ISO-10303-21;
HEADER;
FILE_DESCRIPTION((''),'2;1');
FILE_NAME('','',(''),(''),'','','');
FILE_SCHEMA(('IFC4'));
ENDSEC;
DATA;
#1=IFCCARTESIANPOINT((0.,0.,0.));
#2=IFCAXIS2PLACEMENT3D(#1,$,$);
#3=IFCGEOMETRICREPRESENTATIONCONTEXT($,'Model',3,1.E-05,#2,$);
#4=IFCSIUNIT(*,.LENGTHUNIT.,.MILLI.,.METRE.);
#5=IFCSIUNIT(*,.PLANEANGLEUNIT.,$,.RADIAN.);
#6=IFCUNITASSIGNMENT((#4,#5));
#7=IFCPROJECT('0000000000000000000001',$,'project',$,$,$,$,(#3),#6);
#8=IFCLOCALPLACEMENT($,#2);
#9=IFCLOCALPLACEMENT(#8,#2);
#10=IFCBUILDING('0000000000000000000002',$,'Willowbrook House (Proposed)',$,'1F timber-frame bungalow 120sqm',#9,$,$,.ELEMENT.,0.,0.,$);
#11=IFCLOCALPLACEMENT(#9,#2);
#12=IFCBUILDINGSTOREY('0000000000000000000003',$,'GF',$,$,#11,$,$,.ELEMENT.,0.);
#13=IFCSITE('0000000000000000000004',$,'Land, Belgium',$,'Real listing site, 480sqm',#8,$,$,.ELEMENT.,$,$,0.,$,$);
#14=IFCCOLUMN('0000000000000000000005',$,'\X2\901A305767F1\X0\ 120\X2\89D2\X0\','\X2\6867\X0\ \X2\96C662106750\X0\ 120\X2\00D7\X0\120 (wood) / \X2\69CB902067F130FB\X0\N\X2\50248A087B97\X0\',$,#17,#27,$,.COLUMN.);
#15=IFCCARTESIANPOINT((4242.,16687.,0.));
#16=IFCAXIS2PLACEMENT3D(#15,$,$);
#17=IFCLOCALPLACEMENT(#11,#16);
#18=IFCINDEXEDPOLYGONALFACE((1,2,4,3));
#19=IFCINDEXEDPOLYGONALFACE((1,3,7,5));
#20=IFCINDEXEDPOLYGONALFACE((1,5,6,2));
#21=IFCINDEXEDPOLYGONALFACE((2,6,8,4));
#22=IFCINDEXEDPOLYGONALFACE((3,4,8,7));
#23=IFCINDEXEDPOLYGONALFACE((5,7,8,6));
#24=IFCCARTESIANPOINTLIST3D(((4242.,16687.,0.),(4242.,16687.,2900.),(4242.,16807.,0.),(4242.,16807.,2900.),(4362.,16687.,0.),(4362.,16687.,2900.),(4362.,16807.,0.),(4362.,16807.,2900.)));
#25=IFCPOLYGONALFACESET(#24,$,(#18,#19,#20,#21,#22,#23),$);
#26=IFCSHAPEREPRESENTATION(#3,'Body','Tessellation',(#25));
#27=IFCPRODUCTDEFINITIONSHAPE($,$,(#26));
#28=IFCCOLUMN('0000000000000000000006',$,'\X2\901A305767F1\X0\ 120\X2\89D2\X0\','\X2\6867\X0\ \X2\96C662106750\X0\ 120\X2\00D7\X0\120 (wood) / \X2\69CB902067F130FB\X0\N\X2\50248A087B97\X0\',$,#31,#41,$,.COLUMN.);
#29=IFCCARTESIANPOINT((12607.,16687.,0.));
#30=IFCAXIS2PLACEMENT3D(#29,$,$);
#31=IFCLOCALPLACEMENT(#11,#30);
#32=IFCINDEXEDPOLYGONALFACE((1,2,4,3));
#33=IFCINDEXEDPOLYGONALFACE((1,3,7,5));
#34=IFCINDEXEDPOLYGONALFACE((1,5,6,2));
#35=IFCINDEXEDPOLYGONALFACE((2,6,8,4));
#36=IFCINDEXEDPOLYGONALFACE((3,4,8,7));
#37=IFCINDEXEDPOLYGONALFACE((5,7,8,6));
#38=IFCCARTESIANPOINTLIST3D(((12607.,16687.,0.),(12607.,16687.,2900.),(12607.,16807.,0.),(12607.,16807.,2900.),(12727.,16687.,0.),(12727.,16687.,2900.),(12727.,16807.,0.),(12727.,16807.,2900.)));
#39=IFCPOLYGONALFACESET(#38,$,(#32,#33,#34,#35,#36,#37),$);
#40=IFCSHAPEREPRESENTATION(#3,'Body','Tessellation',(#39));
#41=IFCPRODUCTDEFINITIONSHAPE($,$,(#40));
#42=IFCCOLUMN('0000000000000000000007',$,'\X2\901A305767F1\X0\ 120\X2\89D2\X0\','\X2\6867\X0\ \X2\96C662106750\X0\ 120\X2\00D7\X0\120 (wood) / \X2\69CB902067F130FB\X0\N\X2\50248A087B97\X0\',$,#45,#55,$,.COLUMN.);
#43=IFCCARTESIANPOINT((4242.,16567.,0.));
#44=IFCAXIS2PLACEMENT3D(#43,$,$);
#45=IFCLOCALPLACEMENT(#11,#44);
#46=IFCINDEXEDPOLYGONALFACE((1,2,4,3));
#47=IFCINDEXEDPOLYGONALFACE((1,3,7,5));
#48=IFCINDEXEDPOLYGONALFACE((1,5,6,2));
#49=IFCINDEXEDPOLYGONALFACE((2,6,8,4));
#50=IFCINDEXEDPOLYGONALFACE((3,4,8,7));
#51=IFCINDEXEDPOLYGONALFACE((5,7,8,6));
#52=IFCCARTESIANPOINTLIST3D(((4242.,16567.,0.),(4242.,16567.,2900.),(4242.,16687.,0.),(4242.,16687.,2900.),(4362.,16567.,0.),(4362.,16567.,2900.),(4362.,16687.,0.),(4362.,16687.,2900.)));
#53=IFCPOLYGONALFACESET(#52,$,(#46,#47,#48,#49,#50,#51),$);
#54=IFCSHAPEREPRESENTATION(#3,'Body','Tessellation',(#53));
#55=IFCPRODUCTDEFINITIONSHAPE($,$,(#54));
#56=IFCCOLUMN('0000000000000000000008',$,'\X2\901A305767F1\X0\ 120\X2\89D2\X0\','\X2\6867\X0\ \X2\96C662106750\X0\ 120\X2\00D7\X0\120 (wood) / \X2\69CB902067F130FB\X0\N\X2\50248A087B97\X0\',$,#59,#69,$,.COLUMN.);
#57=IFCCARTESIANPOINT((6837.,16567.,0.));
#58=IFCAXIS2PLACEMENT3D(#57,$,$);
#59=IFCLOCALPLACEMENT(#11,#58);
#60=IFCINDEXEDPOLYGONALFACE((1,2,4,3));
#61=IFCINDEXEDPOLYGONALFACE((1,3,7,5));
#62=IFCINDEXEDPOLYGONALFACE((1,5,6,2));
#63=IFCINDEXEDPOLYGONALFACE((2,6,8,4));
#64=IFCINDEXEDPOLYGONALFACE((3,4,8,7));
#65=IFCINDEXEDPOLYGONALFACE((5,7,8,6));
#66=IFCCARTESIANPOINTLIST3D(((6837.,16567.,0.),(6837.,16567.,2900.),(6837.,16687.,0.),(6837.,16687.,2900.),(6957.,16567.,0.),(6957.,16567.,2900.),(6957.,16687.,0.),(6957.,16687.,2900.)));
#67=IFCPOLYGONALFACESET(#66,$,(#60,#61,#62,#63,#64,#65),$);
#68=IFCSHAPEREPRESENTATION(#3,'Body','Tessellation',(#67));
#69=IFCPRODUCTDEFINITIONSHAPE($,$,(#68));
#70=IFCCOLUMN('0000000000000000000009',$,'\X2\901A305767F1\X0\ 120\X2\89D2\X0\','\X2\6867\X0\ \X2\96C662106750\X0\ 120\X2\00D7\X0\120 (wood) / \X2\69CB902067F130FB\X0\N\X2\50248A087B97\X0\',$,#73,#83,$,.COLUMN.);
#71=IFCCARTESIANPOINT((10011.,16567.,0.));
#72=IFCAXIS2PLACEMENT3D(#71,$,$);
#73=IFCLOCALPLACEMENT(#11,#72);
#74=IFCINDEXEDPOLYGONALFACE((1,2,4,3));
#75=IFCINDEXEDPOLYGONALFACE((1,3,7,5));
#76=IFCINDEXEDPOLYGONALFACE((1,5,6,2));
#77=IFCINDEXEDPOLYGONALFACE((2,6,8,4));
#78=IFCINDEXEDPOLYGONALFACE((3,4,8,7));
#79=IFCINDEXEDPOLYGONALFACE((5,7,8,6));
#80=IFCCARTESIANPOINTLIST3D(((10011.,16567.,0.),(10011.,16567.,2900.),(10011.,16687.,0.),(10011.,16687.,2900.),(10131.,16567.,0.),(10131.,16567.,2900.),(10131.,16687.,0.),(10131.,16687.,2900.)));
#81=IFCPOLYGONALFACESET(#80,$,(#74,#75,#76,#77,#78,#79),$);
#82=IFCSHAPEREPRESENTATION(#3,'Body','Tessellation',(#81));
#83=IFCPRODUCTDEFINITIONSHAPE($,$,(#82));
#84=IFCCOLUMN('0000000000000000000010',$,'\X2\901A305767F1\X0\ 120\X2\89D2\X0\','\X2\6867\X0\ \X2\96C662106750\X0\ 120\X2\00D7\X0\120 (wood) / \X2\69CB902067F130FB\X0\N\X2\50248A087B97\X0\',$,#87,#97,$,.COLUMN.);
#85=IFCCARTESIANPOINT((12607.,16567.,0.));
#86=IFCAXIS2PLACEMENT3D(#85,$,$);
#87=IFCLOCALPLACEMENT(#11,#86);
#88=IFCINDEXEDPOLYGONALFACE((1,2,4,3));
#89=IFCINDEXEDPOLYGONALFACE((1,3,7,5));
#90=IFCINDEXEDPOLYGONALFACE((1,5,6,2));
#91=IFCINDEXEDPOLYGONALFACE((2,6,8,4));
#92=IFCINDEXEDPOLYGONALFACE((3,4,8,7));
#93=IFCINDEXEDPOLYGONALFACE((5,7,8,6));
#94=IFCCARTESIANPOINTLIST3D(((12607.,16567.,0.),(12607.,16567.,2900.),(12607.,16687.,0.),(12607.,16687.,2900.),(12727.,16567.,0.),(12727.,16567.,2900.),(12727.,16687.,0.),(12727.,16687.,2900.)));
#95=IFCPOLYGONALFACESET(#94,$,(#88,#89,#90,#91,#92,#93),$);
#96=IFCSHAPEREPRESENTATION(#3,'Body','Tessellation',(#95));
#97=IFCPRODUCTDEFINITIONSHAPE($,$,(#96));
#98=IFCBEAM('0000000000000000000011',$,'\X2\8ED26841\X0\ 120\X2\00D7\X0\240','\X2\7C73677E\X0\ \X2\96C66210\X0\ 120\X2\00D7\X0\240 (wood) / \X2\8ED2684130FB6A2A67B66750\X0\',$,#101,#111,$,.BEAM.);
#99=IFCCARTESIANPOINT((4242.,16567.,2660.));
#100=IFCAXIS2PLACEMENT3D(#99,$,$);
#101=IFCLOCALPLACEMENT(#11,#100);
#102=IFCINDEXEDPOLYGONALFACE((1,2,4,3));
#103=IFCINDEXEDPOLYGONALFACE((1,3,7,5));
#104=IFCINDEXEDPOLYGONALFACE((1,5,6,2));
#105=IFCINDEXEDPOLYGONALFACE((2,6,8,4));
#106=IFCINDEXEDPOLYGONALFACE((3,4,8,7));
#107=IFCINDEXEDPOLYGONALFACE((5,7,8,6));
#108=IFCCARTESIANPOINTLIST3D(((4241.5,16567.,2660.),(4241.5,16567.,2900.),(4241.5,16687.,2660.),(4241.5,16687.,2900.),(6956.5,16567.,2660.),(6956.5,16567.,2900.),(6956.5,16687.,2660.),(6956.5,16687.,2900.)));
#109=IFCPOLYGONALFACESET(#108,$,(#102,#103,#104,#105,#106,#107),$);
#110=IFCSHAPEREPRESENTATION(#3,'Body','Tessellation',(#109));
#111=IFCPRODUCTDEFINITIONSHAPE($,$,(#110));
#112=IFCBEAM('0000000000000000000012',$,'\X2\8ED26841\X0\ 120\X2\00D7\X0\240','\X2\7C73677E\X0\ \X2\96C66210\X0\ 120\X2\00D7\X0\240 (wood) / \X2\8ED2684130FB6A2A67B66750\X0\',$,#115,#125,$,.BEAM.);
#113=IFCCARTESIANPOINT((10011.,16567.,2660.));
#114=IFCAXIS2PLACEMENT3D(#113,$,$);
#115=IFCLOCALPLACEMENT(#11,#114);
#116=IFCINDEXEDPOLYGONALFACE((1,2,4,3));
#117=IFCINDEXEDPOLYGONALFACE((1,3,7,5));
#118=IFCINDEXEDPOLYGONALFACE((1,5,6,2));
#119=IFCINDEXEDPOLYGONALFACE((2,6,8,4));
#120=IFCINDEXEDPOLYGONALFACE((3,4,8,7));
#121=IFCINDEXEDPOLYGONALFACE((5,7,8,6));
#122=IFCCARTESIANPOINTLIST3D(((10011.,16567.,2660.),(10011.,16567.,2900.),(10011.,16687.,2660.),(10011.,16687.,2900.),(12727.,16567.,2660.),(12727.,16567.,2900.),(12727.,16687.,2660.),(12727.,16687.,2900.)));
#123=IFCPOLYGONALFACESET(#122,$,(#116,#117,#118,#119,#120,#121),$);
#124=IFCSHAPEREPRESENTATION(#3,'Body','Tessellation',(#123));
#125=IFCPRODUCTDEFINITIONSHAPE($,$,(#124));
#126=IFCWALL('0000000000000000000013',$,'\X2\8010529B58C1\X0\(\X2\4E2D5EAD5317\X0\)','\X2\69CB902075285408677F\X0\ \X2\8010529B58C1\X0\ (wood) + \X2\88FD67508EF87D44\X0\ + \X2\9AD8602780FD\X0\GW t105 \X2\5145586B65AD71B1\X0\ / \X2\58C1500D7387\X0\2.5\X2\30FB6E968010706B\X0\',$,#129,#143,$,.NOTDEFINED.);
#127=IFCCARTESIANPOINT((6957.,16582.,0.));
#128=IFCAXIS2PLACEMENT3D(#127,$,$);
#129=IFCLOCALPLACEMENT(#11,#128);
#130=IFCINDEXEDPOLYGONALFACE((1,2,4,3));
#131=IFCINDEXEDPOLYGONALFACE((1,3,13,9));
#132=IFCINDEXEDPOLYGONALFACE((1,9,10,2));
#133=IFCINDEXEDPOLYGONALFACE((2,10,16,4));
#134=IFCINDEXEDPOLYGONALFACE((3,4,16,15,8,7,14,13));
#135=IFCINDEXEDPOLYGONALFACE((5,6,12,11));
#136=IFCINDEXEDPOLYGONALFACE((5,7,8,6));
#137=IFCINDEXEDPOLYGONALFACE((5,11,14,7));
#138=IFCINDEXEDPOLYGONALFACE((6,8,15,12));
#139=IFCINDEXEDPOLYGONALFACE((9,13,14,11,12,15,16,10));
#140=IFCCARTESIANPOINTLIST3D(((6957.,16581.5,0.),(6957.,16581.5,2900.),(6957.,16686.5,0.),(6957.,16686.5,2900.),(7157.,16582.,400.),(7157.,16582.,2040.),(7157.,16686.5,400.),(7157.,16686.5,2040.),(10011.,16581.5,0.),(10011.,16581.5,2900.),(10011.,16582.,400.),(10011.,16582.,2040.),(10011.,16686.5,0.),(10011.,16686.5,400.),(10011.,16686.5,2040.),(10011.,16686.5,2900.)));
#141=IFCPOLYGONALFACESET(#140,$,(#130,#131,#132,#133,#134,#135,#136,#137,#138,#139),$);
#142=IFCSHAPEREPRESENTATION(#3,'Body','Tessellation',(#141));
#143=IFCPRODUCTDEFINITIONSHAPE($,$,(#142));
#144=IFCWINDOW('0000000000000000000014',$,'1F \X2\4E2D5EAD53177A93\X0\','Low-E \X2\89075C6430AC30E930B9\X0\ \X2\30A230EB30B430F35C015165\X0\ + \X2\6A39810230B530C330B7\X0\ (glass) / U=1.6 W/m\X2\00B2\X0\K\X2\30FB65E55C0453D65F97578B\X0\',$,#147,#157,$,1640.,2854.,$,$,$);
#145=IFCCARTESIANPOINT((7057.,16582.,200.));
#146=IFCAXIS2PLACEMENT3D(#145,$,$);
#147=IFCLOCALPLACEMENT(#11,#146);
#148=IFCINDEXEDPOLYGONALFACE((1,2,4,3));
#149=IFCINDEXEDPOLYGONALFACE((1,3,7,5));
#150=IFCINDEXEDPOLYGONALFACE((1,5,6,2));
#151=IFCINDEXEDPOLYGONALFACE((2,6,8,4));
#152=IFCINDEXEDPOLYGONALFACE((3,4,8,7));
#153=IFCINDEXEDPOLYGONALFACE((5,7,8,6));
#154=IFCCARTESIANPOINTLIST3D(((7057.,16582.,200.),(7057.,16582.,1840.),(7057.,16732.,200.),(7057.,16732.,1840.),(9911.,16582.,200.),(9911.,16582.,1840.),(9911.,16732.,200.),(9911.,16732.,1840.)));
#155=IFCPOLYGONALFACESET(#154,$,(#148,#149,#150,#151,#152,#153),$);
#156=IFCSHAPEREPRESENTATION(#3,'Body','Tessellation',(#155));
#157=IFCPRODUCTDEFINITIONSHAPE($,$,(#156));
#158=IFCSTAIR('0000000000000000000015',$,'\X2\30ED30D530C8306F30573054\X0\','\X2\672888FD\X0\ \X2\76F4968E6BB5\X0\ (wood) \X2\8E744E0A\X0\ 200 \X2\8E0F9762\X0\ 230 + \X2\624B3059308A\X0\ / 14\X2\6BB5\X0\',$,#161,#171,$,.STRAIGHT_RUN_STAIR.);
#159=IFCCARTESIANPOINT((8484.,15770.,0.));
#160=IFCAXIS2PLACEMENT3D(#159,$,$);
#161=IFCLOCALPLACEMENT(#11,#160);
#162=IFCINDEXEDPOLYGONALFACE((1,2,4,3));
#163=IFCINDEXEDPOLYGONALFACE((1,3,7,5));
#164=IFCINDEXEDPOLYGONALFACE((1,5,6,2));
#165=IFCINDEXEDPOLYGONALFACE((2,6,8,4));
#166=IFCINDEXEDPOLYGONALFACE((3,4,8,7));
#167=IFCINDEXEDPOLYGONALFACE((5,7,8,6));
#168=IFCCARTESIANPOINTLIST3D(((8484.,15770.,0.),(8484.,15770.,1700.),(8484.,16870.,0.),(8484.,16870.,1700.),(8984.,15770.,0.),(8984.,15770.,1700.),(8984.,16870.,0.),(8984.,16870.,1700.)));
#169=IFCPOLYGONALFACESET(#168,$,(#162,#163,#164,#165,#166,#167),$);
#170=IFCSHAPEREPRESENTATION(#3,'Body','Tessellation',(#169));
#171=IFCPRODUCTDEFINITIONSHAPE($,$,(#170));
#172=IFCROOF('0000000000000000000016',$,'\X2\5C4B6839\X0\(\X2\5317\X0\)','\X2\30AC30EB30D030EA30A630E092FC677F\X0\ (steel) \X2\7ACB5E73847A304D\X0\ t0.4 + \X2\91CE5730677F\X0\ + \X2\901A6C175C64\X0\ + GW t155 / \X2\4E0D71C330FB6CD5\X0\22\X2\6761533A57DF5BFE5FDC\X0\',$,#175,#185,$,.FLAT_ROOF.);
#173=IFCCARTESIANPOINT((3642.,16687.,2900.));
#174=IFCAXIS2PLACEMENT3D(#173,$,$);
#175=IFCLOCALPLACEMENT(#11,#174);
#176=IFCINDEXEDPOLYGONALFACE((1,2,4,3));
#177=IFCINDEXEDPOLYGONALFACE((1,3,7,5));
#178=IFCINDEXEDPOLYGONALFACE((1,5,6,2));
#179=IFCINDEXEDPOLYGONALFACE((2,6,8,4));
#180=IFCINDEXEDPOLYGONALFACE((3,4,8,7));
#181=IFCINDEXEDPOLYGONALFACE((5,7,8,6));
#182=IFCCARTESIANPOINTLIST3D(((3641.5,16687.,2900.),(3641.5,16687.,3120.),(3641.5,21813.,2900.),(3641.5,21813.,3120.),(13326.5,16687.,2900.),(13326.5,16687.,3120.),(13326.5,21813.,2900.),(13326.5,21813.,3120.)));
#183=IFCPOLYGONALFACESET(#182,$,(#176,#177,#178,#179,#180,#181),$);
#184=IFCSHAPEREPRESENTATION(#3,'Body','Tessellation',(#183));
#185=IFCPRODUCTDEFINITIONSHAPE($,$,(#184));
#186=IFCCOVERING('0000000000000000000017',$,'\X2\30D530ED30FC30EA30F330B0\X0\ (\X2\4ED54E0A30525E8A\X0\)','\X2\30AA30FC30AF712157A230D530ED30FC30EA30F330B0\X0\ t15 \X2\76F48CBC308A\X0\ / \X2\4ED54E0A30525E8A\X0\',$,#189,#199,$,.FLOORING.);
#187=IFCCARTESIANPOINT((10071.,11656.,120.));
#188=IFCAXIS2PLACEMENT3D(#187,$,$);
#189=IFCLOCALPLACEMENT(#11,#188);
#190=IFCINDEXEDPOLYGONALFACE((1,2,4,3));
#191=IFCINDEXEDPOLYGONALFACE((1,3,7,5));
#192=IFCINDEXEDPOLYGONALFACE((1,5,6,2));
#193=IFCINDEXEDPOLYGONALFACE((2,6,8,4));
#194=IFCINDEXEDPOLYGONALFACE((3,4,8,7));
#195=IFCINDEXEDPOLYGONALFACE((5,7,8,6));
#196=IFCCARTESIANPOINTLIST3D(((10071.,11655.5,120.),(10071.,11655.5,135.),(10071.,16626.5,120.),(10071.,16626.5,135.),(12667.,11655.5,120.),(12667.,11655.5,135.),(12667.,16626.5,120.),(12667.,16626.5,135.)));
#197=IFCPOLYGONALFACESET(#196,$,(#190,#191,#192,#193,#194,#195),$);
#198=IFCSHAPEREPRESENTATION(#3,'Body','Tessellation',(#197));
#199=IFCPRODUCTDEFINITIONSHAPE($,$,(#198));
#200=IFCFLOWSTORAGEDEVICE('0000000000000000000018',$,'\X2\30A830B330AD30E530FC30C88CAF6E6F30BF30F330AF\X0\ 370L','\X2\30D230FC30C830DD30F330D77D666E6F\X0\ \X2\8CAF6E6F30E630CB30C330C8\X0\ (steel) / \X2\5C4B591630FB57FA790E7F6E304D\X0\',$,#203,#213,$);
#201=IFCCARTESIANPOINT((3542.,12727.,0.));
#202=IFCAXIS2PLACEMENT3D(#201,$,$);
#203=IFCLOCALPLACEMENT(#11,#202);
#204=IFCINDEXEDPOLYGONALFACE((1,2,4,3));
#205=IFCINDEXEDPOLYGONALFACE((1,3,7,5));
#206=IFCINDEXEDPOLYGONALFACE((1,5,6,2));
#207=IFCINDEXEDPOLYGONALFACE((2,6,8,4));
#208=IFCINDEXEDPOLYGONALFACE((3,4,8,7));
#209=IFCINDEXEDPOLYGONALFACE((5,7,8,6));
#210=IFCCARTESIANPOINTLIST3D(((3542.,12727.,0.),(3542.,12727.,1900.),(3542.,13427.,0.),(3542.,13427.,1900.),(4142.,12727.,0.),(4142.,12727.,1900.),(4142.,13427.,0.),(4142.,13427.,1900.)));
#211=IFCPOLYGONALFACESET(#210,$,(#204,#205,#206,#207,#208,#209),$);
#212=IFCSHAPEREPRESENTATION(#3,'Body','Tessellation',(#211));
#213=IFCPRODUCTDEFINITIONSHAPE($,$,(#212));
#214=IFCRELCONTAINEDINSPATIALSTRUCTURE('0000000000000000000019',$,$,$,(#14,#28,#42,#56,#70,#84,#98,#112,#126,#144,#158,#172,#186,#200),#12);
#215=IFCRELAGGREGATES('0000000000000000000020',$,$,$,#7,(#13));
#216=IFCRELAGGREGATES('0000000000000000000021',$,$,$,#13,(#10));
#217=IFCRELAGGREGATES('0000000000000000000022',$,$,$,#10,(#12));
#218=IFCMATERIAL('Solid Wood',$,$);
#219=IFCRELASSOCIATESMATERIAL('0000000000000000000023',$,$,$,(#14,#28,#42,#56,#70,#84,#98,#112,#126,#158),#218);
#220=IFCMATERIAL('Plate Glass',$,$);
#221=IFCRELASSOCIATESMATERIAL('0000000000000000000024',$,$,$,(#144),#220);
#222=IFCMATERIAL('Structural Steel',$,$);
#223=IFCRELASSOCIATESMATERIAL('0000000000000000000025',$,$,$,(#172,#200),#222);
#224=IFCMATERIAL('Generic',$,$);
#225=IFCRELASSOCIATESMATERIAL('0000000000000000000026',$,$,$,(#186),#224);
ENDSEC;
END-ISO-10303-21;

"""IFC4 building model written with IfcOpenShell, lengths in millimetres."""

from ifc_helpers import new_model, si_unit, frame, frame_2d, origin, place, context, project, spatial, rectangle, extrude, material, element, fill, save


model = new_model("IFC4")

# Units and contexts
model_context = context("Model", 3, precision=1e-05, world=origin())
ifc_project = project(units=[si_unit("LENGTHUNIT", "METRE", prefix="MILLI"), si_unit("PLANEANGLEUNIT", "RADIAN")], contexts=[model_context])

# Site, building, storey
site_placement = place(None, origin())
site = spatial("IfcSite", under=ifc_project, at=site_placement, Name="Land, Belgium", ObjectType="Real listing site, 480sqm", CompositionType="ELEMENT", RefElevation=0.0)
building_placement = place(site_placement, origin())
building = spatial("IfcBuilding", under=site, at=building_placement, Name="Willowbrook House (Proposed)", ObjectType="1F timber-frame bungalow 120sqm", CompositionType="ELEMENT", ElevationOfRefHeight=0.0, ElevationOfTerrain=0.0)
storey_placement = place(building_placement, origin())
storey = spatial("IfcBuildingStorey", under=building, at=storey_placement, Name="GF", CompositionType="ELEMENT", Elevation=0.0)

# Columns
ifc_material_1 = material(Name="Solid Wood")
column_1_placement = place(storey_placement, frame((4242.0, 16687.0, 0.0)))
element("IfcColumn", 1, at=column_1_placement, inside=storey, material=ifc_material_1, Name="通し柱 120角", Description="桧 集成材 120×120 (wood) / 構造柱・N値計算", PredefinedType="COLUMN", context=model_context, shape_type="SweptSolid", body=[
    extrude(rectangle(XDim=120.0, YDim=120.0, at=frame_2d((60.0, 60.0))), frame((4242.0, 16687.0, 0.0)), (0.0, 0.0, 1.0), 2900.0),
])
column_2_placement = place(storey_placement, frame((12607.0, 16687.0, 0.0)))
element("IfcColumn", 2, at=column_2_placement, inside=storey, material=ifc_material_1, Name="通し柱 120角", Description="桧 集成材 120×120 (wood) / 構造柱・N値計算", PredefinedType="COLUMN", context=model_context, shape_type="SweptSolid", body=[
    extrude(rectangle(XDim=120.0, YDim=120.0, at=frame_2d((60.0, 60.0))), frame((12607.0, 16687.0, 0.0)), (0.0, 0.0, 1.0), 2900.0),
])
column_3_placement = place(storey_placement, frame((4242.0, 16567.0, 0.0)))
element("IfcColumn", 3, at=column_3_placement, inside=storey, material=ifc_material_1, Name="通し柱 120角", Description="桧 集成材 120×120 (wood) / 構造柱・N値計算", PredefinedType="COLUMN", context=model_context, shape_type="SweptSolid", body=[
    extrude(rectangle(XDim=120.0, YDim=120.0, at=frame_2d((60.0, 60.0))), frame((4242.0, 16567.0, 0.0)), (0.0, 0.0, 1.0), 2900.0),
])
column_4_placement = place(storey_placement, frame((6837.0, 16567.0, 0.0)))
element("IfcColumn", 4, at=column_4_placement, inside=storey, material=ifc_material_1, Name="通し柱 120角", Description="桧 集成材 120×120 (wood) / 構造柱・N値計算", PredefinedType="COLUMN", context=model_context, shape_type="SweptSolid", body=[
    extrude(rectangle(XDim=120.0, YDim=120.0, at=frame_2d((60.0, 60.0))), frame((6837.0, 16567.0, 0.0)), (0.0, 0.0, 1.0), 2900.0),
])
column_5_placement = place(storey_placement, frame((10011.0, 16567.0, 0.0)))
element("IfcColumn", 5, at=column_5_placement, inside=storey, material=ifc_material_1, Name="通し柱 120角", Description="桧 集成材 120×120 (wood) / 構造柱・N値計算", PredefinedType="COLUMN", context=model_context, shape_type="SweptSolid", body=[
    extrude(rectangle(XDim=120.0, YDim=120.0, at=frame_2d((60.0, 60.0))), frame((10011.0, 16567.0, 0.0)), (0.0, 0.0, 1.0), 2900.0),
])
column_6_placement = place(storey_placement, frame((12607.0, 16567.0, 0.0)))
element("IfcColumn", 6, at=column_6_placement, inside=storey, material=ifc_material_1, Name="通し柱 120角", Description="桧 集成材 120×120 (wood) / 構造柱・N値計算", PredefinedType="COLUMN", context=model_context, shape_type="SweptSolid", body=[
    extrude(rectangle(XDim=120.0, YDim=120.0, at=frame_2d((60.0, 60.0))), frame((12607.0, 16567.0, 0.0)), (0.0, 0.0, 1.0), 2900.0),
])

# Beams
beam_1_placement = place(storey_placement, frame((4242.0, 16567.0, 2660.0)))
element("IfcBeam", 7, at=beam_1_placement, inside=storey, material=ifc_material_1, Name="軒桁 120×240", Description="米松 集成 120×240 (wood) / 軒桁・横架材", PredefinedType="BEAM", context=model_context, shape_type="SweptSolid", body=[
    extrude(rectangle(XDim=2715.0, YDim=120.0, at=frame_2d((1357.0, 60.0))), frame((4242.0, 16567.0, 2660.0)), (0.0, 0.0, 1.0), 240.0),
])
beam_2_placement = place(storey_placement, frame((10011.0, 16567.0, 2660.0)))
element("IfcBeam", 8, at=beam_2_placement, inside=storey, material=ifc_material_1, Name="軒桁 120×240", Description="米松 集成 120×240 (wood) / 軒桁・横架材", PredefinedType="BEAM", context=model_context, shape_type="SweptSolid", body=[
    extrude(rectangle(XDim=2716.0, YDim=120.0, at=frame_2d((1358.0, 60.0))), frame((10011.0, 16567.0, 2660.0)), (0.0, 0.0, 1.0), 240.0),
])

# Wall, opening, window
wall_placement = place(storey_placement, frame((6957.0, 16582.0, 0.0)))
wall = element("IfcWall", 9, at=wall_placement, inside=storey, material=ifc_material_1, Name="耐力壁(中庭北)", Description="構造用合板 耐力壁 (wood) + 製材軸組 + 高性能GW t105 充填断熱 / 壁倍率2.5・準耐火", PredefinedType="NOTDEFINED", context=model_context, shape_type="SweptSolid", body=[
    extrude(rectangle(XDim=3054.0, YDim=105.0, at=frame_2d((1527.0, 52.0))), frame((6957.0, 16582.0, 0.0)), (0.0, 0.0, 1.0), 2900.0),
])
opening_placement = place(storey_placement, frame((7057.0, 16582.0, 200.0)))
opening = element("IfcOpeningElement", 10, at=opening_placement, cuts=wall, PredefinedType="NOTDEFINED", context=model_context, shape_type="SweptSolid", body=[
    extrude(rectangle(XDim=2854.0, YDim=150.0, at=frame_2d((1427.0, 75.0))), frame((7057.0, 16582.0, 200.0)), (0.0, 0.0, 1.0), 1640.0),
])
ifc_material_2 = material(Name="Plate Glass")
window_placement = place(storey_placement, frame((7057.0, 16582.0, 200.0)))
window = element("IfcWindow", 11, at=window_placement, inside=storey, material=ifc_material_2, Name="1F 中庭北窓", Description="Low-E 複層ガラス アルゴン封入 + 樹脂サッシ (glass) / U=1.6 W/m²K・日射取得型", OverallHeight=1640.0, OverallWidth=2854.0, context=model_context, shape_type="SweptSolid", body=[
    extrude(rectangle(XDim=2854.0, YDim=150.0, at=frame_2d((1427.0, 75.0))), frame((7057.0, 16582.0, 200.0)), (0.0, 0.0, 1.0), 1640.0),
])
fill(opening, window)

# Stair
stair_placement = place(storey_placement, frame((8484.0, 15770.0, 0.0)))
element("IfcStair", 12, at=stair_placement, inside=storey, material=ifc_material_1, Name="ロフトはしご", Description="木製 直階段 (wood) 蹴上 200 踏面 230 + 手すり / 14段", PredefinedType="STRAIGHT_RUN_STAIR", context=model_context, shape_type="SweptSolid", body=[
    extrude(rectangle(XDim=500.0, YDim=1100.0, at=frame_2d((250.0, 550.0))), frame((8484.0, 15770.0, 0.0)), (0.0, 0.0, 1.0), 1700.0),
])

# Roof
ifc_material_3 = material(Name="Structural Steel")
roof_placement = place(storey_placement, frame((3642.0, 16687.0, 2900.0)))
element("IfcRoof", 13, at=roof_placement, inside=storey, material=ifc_material_3, Name="屋根(北)", Description="ガルバリウム鋼板 (steel) 立平葺き t0.4 + 野地板 + 通気層 + GW t155 / 不燃・法22条区域対応", PredefinedType="FLAT_ROOF", context=model_context, shape_type="SweptSolid", body=[
    extrude(rectangle(XDim=9685.0, YDim=5126.0, at=frame_2d((4842.0, 2563.0))), frame((3642.0, 16687.0, 2900.0)), (0.0, 0.0, 1.0), 220.0),
])

# Covering
ifc_material_4 = material(Name="Generic")
covering_1_placement = place(storey_placement, frame((10071.0, 11656.0, 120.0)))
element("IfcCovering", 14, at=covering_1_placement, inside=storey, material=ifc_material_4, Name="フローリング (仕上げ床)", Description="オーク無垢フローリング t15 直貼り / 仕上げ床", PredefinedType="FLOORING", context=model_context, shape_type="SweptSolid", body=[
    extrude(rectangle(XDim=2596.0, YDim=4971.0, at=frame_2d((1298.0, 2485.0))), frame((10071.0, 11656.0, 120.0)), (0.0, 0.0, 1.0), 15.0),
])

# Flow storage device
flow_storage_device_placement = place(storey_placement, frame((3542.0, 12727.0, 0.0)))
element("IfcFlowStorageDevice", 15, at=flow_storage_device_placement, inside=storey, material=ifc_material_3, Name="エコキュート貯湯タンク 370L", Description="ヒートポンプ給湯 貯湯ユニット (steel) / 屋外・基礎置き", context=model_context, shape_type="SweptSolid", body=[
    extrude(rectangle(XDim=600.0, YDim=700.0, at=frame_2d((300.0, 350.0))), frame((3542.0, 12727.0, 0.0)), (0.0, 0.0, 1.0), 1900.0),
])

save(model, "model.ifc")
